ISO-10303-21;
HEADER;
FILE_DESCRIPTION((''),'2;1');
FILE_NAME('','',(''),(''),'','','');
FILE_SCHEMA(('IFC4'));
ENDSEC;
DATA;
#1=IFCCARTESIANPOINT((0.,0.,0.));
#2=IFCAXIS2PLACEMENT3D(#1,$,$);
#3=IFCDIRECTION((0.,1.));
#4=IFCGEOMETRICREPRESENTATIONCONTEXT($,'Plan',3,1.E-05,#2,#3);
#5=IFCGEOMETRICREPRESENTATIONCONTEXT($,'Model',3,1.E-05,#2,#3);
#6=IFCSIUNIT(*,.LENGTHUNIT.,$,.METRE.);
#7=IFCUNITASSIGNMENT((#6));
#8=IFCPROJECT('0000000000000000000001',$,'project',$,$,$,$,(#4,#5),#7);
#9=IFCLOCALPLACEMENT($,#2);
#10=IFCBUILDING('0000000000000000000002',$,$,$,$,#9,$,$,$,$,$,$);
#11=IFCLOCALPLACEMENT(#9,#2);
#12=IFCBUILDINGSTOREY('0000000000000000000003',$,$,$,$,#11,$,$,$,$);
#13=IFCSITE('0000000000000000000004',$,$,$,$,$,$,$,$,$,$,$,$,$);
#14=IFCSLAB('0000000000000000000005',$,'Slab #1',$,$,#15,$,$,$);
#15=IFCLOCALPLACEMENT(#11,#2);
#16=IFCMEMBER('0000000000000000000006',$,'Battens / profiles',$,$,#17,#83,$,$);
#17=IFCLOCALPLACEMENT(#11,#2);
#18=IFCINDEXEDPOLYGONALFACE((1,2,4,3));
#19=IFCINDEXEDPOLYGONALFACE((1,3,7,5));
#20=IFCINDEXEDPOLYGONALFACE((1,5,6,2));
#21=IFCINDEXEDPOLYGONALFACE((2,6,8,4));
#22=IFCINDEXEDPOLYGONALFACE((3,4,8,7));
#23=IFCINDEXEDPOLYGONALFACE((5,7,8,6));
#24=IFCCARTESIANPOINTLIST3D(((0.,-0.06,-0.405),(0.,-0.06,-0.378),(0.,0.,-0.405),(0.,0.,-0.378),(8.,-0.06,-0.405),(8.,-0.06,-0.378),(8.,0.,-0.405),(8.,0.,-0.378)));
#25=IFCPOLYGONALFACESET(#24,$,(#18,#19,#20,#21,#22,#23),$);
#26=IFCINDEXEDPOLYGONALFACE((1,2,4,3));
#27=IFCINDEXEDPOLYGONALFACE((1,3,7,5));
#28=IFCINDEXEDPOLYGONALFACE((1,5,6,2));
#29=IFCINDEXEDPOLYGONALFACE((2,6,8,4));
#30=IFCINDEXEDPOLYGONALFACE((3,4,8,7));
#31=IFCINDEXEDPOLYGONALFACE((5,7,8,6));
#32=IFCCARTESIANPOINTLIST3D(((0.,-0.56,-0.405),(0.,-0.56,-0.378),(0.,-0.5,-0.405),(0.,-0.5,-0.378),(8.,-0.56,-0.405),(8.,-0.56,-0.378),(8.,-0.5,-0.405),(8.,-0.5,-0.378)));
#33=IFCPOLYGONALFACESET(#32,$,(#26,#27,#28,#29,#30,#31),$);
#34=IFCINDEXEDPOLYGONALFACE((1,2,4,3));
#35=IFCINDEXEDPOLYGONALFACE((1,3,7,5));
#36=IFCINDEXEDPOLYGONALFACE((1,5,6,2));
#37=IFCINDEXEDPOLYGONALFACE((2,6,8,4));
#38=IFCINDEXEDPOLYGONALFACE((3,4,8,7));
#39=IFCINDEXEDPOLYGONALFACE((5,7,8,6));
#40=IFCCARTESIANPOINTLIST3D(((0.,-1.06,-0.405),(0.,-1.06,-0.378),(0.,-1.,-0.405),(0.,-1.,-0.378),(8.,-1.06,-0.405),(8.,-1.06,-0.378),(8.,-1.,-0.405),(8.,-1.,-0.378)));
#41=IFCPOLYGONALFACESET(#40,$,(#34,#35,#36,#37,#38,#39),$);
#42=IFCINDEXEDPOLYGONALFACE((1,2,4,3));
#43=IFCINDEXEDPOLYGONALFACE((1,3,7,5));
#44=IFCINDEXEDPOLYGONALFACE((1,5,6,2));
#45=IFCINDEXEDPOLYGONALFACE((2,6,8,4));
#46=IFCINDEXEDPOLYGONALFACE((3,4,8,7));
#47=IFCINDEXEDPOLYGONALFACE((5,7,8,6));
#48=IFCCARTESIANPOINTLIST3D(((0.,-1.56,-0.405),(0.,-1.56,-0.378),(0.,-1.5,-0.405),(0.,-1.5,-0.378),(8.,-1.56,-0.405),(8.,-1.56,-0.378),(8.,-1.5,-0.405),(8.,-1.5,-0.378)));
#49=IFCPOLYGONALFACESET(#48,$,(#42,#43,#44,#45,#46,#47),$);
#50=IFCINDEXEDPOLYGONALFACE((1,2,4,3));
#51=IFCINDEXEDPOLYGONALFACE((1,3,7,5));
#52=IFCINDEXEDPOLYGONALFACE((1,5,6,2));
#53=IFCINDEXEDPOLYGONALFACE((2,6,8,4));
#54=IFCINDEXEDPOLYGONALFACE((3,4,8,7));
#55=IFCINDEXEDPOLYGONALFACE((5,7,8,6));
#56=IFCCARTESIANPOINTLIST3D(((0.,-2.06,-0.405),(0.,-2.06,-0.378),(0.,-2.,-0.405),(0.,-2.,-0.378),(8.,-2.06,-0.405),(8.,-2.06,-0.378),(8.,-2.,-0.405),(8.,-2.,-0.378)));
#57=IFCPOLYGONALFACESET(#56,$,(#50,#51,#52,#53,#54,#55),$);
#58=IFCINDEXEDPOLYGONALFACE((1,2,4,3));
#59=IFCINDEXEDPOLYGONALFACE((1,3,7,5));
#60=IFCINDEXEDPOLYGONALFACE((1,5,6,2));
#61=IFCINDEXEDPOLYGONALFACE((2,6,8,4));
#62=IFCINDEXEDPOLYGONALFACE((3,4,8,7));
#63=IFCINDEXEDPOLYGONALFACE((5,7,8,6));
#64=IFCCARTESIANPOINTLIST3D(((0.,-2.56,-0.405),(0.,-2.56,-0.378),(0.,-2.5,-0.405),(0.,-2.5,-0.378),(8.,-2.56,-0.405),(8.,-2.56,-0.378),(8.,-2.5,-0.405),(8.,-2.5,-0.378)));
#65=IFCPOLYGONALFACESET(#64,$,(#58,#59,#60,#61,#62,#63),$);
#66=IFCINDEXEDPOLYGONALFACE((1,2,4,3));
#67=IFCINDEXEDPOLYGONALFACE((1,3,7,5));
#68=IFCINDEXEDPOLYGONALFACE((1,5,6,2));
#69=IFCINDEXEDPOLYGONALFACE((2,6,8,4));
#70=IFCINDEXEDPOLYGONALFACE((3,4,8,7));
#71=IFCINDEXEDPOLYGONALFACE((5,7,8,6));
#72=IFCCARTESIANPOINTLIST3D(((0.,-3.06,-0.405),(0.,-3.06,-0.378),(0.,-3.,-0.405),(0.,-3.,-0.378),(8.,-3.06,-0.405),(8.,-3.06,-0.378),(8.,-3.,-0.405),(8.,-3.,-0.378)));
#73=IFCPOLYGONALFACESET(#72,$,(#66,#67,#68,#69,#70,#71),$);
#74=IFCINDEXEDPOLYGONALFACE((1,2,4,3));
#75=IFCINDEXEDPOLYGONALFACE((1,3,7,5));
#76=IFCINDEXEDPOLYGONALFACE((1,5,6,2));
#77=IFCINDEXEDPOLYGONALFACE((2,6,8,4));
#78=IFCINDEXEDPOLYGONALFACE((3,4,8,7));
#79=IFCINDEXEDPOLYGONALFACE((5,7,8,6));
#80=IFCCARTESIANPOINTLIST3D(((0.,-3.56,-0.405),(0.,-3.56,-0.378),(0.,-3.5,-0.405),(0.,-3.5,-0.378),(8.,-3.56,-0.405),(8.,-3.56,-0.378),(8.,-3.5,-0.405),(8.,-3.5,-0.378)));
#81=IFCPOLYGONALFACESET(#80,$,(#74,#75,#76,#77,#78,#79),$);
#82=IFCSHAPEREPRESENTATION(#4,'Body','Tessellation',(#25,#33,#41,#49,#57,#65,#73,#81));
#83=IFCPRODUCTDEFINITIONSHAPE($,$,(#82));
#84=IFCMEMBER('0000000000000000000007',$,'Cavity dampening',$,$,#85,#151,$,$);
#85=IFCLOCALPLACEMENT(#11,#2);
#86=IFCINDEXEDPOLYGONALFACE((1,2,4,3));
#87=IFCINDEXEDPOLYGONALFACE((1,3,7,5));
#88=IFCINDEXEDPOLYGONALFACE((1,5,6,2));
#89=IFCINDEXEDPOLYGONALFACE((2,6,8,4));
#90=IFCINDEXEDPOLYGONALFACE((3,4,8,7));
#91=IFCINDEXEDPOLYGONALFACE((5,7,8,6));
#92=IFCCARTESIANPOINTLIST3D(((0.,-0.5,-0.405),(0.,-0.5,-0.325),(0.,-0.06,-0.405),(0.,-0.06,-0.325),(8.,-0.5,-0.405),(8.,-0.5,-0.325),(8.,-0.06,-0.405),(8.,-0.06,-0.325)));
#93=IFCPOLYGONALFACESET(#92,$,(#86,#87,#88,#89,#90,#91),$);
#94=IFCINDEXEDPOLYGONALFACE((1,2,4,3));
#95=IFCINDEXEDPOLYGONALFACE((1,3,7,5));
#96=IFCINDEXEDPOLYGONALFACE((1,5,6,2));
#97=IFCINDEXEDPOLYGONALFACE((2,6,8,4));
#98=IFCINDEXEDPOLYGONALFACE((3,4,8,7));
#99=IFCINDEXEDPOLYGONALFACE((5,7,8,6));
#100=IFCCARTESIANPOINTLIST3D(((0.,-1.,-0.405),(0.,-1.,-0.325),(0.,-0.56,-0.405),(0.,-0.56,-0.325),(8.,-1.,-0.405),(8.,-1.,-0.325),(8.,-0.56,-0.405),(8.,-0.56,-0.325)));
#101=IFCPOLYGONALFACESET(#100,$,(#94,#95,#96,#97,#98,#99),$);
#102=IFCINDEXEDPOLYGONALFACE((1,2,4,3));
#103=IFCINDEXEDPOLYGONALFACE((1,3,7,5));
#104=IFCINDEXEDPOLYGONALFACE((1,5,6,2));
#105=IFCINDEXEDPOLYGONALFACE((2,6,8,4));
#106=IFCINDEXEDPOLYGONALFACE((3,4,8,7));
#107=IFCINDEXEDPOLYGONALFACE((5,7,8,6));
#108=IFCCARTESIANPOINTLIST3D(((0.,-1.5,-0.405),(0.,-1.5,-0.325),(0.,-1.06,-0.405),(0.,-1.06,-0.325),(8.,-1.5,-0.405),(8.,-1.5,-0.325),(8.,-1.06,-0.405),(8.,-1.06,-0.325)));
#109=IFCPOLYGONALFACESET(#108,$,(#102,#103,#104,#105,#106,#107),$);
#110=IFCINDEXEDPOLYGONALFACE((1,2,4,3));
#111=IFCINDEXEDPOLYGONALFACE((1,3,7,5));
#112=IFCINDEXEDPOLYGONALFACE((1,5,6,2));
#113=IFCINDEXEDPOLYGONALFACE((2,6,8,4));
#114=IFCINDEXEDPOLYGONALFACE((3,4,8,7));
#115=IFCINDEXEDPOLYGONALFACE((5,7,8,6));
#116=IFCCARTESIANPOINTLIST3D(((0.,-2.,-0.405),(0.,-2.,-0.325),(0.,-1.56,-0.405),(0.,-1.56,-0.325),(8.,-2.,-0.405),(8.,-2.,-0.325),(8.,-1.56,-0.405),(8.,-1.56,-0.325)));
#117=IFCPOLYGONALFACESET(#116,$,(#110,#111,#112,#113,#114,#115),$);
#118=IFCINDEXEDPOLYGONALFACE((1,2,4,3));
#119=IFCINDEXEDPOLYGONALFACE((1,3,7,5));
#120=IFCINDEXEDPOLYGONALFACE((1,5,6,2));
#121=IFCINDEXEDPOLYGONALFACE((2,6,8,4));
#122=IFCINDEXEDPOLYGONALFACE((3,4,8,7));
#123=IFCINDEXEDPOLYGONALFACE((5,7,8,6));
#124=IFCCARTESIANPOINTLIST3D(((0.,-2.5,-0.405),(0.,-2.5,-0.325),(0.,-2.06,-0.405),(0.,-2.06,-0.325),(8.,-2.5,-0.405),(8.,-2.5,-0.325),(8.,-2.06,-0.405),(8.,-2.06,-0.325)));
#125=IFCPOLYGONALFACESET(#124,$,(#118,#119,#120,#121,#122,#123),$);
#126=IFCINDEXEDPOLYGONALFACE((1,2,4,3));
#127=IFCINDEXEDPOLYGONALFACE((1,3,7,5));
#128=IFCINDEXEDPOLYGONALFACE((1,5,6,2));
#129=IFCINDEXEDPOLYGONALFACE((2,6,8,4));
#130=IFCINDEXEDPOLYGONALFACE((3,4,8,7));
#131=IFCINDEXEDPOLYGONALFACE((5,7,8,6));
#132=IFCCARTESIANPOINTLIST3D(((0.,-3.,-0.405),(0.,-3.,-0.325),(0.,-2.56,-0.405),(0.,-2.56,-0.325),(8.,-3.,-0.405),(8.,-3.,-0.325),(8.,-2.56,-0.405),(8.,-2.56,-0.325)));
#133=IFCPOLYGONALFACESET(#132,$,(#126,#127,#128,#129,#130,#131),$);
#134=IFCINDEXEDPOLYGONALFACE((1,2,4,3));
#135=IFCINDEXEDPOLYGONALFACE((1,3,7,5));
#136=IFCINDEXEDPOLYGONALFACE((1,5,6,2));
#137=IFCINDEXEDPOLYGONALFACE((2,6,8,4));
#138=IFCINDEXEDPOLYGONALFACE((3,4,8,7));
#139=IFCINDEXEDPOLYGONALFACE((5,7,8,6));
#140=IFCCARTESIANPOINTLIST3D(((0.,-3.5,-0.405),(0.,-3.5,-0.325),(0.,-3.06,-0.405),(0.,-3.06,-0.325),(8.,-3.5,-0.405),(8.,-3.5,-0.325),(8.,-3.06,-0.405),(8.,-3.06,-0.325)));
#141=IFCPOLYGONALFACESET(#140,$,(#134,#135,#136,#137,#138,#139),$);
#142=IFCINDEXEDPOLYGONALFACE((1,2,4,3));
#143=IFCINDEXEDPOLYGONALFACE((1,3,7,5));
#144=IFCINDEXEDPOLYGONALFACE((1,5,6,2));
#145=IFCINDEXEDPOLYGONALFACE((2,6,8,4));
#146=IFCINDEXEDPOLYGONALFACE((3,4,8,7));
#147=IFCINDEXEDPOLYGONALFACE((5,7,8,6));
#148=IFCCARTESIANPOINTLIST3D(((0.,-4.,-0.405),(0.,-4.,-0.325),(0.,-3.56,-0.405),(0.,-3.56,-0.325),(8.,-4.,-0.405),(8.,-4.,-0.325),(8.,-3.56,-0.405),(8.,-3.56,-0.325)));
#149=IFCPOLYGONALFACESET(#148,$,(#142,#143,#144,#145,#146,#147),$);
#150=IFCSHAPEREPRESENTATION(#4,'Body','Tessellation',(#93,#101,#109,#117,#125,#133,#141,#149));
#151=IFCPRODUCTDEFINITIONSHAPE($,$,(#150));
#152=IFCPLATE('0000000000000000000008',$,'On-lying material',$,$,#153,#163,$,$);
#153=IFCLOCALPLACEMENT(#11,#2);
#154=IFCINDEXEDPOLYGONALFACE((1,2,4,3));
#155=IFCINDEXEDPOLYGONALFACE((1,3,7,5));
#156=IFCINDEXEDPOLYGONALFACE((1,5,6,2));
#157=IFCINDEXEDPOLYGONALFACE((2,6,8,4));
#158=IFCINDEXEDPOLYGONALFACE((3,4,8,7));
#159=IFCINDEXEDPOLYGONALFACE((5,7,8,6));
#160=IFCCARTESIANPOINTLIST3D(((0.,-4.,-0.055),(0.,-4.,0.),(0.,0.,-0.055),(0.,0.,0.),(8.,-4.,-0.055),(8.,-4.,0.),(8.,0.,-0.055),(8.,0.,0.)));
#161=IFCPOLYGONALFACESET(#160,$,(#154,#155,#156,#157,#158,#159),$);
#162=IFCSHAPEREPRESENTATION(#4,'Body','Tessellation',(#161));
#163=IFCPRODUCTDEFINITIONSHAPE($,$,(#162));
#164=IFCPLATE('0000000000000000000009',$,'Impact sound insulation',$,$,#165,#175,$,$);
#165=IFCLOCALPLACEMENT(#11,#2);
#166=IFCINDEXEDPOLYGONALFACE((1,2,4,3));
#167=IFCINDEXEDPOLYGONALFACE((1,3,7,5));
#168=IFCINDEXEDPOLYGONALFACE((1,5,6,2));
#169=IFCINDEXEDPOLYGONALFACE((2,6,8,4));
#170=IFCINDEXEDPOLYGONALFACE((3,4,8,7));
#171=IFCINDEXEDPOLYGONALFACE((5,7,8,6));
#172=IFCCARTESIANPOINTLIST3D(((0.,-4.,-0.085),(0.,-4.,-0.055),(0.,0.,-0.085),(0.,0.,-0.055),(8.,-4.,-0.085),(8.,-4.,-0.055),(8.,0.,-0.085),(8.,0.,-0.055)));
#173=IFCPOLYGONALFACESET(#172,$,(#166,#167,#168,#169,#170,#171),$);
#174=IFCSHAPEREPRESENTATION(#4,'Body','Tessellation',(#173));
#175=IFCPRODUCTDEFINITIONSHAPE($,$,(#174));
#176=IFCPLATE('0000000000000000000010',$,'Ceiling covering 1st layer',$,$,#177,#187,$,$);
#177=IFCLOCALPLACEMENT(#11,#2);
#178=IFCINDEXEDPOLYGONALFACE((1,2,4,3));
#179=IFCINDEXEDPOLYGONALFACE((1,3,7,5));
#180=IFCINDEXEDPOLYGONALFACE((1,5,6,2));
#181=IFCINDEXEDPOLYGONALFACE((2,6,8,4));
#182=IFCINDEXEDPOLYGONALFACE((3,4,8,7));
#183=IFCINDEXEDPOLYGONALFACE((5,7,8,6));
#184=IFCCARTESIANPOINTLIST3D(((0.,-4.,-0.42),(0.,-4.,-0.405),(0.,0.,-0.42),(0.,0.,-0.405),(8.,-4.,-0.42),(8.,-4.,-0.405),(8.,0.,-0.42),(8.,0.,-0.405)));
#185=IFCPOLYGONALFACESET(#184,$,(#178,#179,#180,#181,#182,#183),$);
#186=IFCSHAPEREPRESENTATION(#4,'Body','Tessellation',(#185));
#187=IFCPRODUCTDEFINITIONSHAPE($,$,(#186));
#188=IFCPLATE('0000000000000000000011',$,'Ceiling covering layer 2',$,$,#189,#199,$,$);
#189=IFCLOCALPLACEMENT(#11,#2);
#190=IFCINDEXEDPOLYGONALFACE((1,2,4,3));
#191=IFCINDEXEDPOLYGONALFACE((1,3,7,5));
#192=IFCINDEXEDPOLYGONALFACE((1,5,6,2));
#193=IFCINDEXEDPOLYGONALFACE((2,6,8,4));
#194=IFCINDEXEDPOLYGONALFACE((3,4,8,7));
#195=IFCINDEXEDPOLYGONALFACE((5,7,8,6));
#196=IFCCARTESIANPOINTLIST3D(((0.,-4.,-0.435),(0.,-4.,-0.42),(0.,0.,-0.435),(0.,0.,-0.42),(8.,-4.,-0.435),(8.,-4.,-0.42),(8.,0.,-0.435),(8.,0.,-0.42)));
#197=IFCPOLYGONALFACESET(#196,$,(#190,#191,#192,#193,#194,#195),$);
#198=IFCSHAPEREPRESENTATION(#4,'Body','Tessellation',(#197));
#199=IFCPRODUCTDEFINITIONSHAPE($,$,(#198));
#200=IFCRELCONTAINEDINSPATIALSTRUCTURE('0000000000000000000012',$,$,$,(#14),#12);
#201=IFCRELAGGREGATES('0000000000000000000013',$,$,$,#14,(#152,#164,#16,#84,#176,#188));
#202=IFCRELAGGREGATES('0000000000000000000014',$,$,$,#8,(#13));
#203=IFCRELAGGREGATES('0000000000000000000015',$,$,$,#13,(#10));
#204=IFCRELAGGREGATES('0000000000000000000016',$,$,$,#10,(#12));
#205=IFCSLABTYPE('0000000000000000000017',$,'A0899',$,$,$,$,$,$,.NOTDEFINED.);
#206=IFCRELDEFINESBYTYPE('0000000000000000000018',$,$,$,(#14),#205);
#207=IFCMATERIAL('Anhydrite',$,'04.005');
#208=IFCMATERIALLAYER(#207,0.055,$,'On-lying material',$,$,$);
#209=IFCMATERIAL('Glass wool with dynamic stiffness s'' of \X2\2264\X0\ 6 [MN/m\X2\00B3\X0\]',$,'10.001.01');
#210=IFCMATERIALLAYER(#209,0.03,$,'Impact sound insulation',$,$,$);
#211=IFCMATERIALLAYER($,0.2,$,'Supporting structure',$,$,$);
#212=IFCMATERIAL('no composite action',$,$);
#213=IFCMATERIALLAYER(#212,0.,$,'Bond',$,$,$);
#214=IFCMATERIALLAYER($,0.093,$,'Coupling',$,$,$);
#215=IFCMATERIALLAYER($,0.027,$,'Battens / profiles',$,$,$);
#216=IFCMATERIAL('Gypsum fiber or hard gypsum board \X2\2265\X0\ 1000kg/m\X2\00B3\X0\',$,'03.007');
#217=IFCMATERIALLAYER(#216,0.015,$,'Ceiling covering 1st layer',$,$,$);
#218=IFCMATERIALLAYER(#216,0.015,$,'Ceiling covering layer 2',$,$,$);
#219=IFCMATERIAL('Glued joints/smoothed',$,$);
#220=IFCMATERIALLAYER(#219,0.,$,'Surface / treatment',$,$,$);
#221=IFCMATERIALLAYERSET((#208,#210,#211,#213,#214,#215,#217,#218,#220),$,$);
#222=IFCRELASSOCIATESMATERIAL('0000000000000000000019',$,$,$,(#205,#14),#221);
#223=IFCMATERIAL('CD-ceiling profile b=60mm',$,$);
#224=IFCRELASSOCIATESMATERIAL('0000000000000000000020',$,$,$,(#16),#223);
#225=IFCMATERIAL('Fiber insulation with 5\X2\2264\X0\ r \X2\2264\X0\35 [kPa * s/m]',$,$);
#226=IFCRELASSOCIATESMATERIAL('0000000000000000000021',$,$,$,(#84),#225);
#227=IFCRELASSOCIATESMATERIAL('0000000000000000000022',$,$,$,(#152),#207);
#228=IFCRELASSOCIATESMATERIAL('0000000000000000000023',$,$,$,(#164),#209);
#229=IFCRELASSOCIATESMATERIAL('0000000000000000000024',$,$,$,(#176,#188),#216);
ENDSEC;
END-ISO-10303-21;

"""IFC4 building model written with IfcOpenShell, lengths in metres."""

from ifc_helpers import new_model, si_unit, direction, frame, frame_2d, origin, origin_with_axes, place, context, project, spatial, rectangle, extrude, material, layer, layer_set, type_object, element, aggregate, save


model = new_model("IFC4")

# Units and contexts
plan_context = context("Plan", 3, precision=1e-05, world=origin(), true_north=direction((0.0, 1.0)))
model_context = context("Model", 3, precision=1e-05, world=origin(), true_north=direction((0.0, 1.0)))
ifc_project = project(units=[si_unit("LENGTHUNIT", "METRE")], contexts=[plan_context, model_context])

# Site, building, storey
site = spatial("IfcSite", under=ifc_project)
building_placement = place(None, origin())
building = spatial("IfcBuilding", under=site, at=building_placement)
storey_placement = place(building_placement, origin())
storey = spatial("IfcBuildingStorey", under=building, at=storey_placement)

# Slab, members, plates
ifc_material_1 = material(Name="Anhydrite", Category="04.005")
ifc_layer_1 = layer(ifc_material_1, 0.055, Name="On-lying material")
ifc_material_2 = material(Name="Glass wool with dynamic stiffness s' of ≤ 6 [MN/m³]", Category="10.001.01")
ifc_layer_2 = layer(ifc_material_2, 0.03, Name="Impact sound insulation")
ifc_layer_3 = layer(None, 0.2, Name="Supporting structure")
ifc_material_3 = material(Name="no composite action")
ifc_layer_4 = layer(ifc_material_3, 0.0, Name="Bond")
ifc_layer_5 = layer(None, 0.093, Name="Coupling")
ifc_layer_6 = layer(None, 0.027, Name="Battens / profiles")
ifc_material_4 = material(Name="Gypsum fiber or hard gypsum board ≥ 1000kg/m³", Category="03.007")
ifc_layer_7 = layer(ifc_material_4, 0.015, Name="Ceiling covering 1st layer")
ifc_layer_8 = layer(ifc_material_4, 0.015, Name="Ceiling covering layer 2")
ifc_material_5 = material(Name="Glued joints/smoothed")
ifc_layer_9 = layer(ifc_material_5, 0.0, Name="Surface / treatment")
ifc_layer_set = layer_set([ifc_layer_1, ifc_layer_2, ifc_layer_3, ifc_layer_4, ifc_layer_5, ifc_layer_6, ifc_layer_7, ifc_layer_8, ifc_layer_9])
slab_type = type_object("IfcSlabType", Name="A0899", PredefinedType="NOTDEFINED", material=ifc_layer_set)
slab_placement = place(None, frame((0.0, 0.0, 0.0), z_axis=(0.0, 0.0, -1.0), x_axis=(1.0, 0.0, 0.0)))
slab = element("IfcSlab", 1, at=slab_placement, inside=storey, type_object=slab_type, material=ifc_layer_set, Name="Slab #1")
ifc_material_6 = material(Name="CD-ceiling profile b=60mm")
member_1_placement = place(slab_placement, origin())
member_1 = element("IfcMember", 2, at=member_1_placement, material=ifc_material_6, Name="Battens / profiles", context=plan_context, shape_type="SweptSolid", body=[
    extrude(rectangle(XDim=0.06, YDim=0.027, at=frame_2d((0.03, 0.0135), x_axis=(1.0, 0.0))), frame((0.0, 0.0, 0.378), z_axis=(1.0, 0.0, 0.0), x_axis=(0.0, 1.0, 0.0)), (0.0, 0.0, 1.0), 8.0),
    extrude(rectangle(XDim=0.06, YDim=0.027, at=frame_2d((0.03, 0.0135), x_axis=(1.0, 0.0))), frame((0.0, 0.5, 0.378), z_axis=(1.0, 0.0, 0.0), x_axis=(0.0, 1.0, 0.0)), (0.0, 0.0, 1.0), 8.0),
    extrude(rectangle(XDim=0.06, YDim=0.027, at=frame_2d((0.03, 0.0135), x_axis=(1.0, 0.0))), frame((0.0, 1.0, 0.378), z_axis=(1.0, 0.0, 0.0), x_axis=(0.0, 1.0, 0.0)), (0.0, 0.0, 1.0), 8.0),
    extrude(rectangle(XDim=0.06, YDim=0.027, at=frame_2d((0.03, 0.0135), x_axis=(1.0, 0.0))), frame((0.0, 1.5, 0.378), z_axis=(1.0, 0.0, 0.0), x_axis=(0.0, 1.0, 0.0)), (0.0, 0.0, 1.0), 8.0),
    extrude(rectangle(XDim=0.06, YDim=0.027, at=frame_2d((0.03, 0.0135), x_axis=(1.0, 0.0))), frame((0.0, 2.0, 0.378), z_axis=(1.0, 0.0, 0.0), x_axis=(0.0, 1.0, 0.0)), (0.0, 0.0, 1.0), 8.0),
    extrude(rectangle(XDim=0.06, YDim=0.027, at=frame_2d((0.03, 0.0135), x_axis=(1.0, 0.0))), frame((0.0, 2.5, 0.378), z_axis=(1.0, 0.0, 0.0), x_axis=(0.0, 1.0, 0.0)), (0.0, 0.0, 1.0), 8.0),
    extrude(rectangle(XDim=0.06, YDim=0.027, at=frame_2d((0.03, 0.0135), x_axis=(1.0, 0.0))), frame((0.0, 3.0, 0.378), z_axis=(1.0, 0.0, 0.0), x_axis=(0.0, 1.0, 0.0)), (0.0, 0.0, 1.0), 8.0),
    extrude(rectangle(XDim=0.06, YDim=0.027, at=frame_2d((0.03, 0.0135), x_axis=(1.0, 0.0))), frame((0.0, 3.5, 0.378), z_axis=(1.0, 0.0, 0.0), x_axis=(0.0, 1.0, 0.0)), (0.0, 0.0, 1.0), 8.0),
])
ifc_material_7 = material(Name="Fiber insulation with 5≤ r ≤35 [kPa * s/m]")
member_2_placement = place(slab_placement, origin())
member_2 = element("IfcMember", 3, at=member_2_placement, material=ifc_material_7, Name="Cavity dampening", context=plan_context, shape_type="SweptSolid", body=[
    extrude(rectangle(XDim=0.44, YDim=0.08, at=frame_2d((0.22, 0.04), x_axis=(1.0, 0.0))), frame((0.0, 0.06, 0.325), z_axis=(1.0, 0.0, 0.0), x_axis=(0.0, 1.0, 0.0)), (0.0, 0.0, 1.0), 8.0),
    extrude(rectangle(XDim=0.44, YDim=0.08, at=frame_2d((0.22, 0.04), x_axis=(1.0, 0.0))), frame((0.0, 0.56, 0.325), z_axis=(1.0, 0.0, 0.0), x_axis=(0.0, 1.0, 0.0)), (0.0, 0.0, 1.0), 8.0),
    extrude(rectangle(XDim=0.44, YDim=0.08, at=frame_2d((0.22, 0.04), x_axis=(1.0, 0.0))), frame((0.0, 1.06, 0.325), z_axis=(1.0, 0.0, 0.0), x_axis=(0.0, 1.0, 0.0)), (0.0, 0.0, 1.0), 8.0),
    extrude(rectangle(XDim=0.44, YDim=0.08, at=frame_2d((0.22, 0.04), x_axis=(1.0, 0.0))), frame((0.0, 1.56, 0.325), z_axis=(1.0, 0.0, 0.0), x_axis=(0.0, 1.0, 0.0)), (0.0, 0.0, 1.0), 8.0),
    extrude(rectangle(XDim=0.44, YDim=0.08, at=frame_2d((0.22, 0.04), x_axis=(1.0, 0.0))), frame((0.0, 2.06, 0.325), z_axis=(1.0, 0.0, 0.0), x_axis=(0.0, 1.0, 0.0)), (0.0, 0.0, 1.0), 8.0),
    extrude(rectangle(XDim=0.44, YDim=0.08, at=frame_2d((0.22, 0.04), x_axis=(1.0, 0.0))), frame((0.0, 2.56, 0.325), z_axis=(1.0, 0.0, 0.0), x_axis=(0.0, 1.0, 0.0)), (0.0, 0.0, 1.0), 8.0),
    extrude(rectangle(XDim=0.44, YDim=0.08, at=frame_2d((0.22, 0.04), x_axis=(1.0, 0.0))), frame((0.0, 3.06, 0.325), z_axis=(1.0, 0.0, 0.0), x_axis=(0.0, 1.0, 0.0)), (0.0, 0.0, 1.0), 8.0),
    extrude(rectangle(XDim=0.44, YDim=0.08, at=frame_2d((0.22, 0.04), x_axis=(1.0, 0.0))), frame((0.0, 3.56, 0.325), z_axis=(1.0, 0.0, 0.0), x_axis=(0.0, 1.0, 0.0)), (0.0, 0.0, 1.0), 8.0),
])
plate_1_placement = place(slab_placement, origin())
plate_1 = element("IfcPlate", 4, at=plate_1_placement, material=ifc_material_1, Name="On-lying material", context=plan_context, shape_type="SweptSolid", body=[
    extrude(rectangle(XDim=8.0, YDim=4.0, at=frame_2d((4.0, 2.0), x_axis=(1.0, 0.0))), origin_with_axes(), (0.0, 0.0, 1.0), 0.055),
])
plate_2_placement = place(slab_placement, origin())
plate_2 = element("IfcPlate", 5, at=plate_2_placement, material=ifc_material_2, Name="Impact sound insulation", context=plan_context, shape_type="SweptSolid", body=[
    extrude(rectangle(XDim=8.0, YDim=4.0, at=frame_2d((4.0, 2.0), x_axis=(1.0, 0.0))), frame((0.0, 0.0, 0.055), z_axis=(0.0, 0.0, 1.0), x_axis=(1.0, 0.0, 0.0)), (0.0, 0.0, 1.0), 0.03),
])
plate_3_placement = place(slab_placement, origin())
plate_3 = element("IfcPlate", 6, at=plate_3_placement, material=ifc_material_4, Name="Ceiling covering 1st layer", context=plan_context, shape_type="SweptSolid", body=[
    extrude(rectangle(XDim=8.0, YDim=4.0, at=frame_2d((4.0, 2.0), x_axis=(1.0, 0.0))), frame((0.0, 0.0, 0.405), z_axis=(0.0, 0.0, 1.0), x_axis=(1.0, 0.0, 0.0)), (0.0, 0.0, 1.0), 0.015),
])
plate_4_placement = place(slab_placement, origin())
plate_4 = element("IfcPlate", 7, at=plate_4_placement, material=ifc_material_4, Name="Ceiling covering layer 2", context=plan_context, shape_type="SweptSolid", body=[
    extrude(rectangle(XDim=8.0, YDim=4.0, at=frame_2d((4.0, 2.0), x_axis=(1.0, 0.0))), frame((0.0, 0.0, 0.42), z_axis=(0.0, 0.0, 1.0), x_axis=(1.0, 0.0, 0.0)), (0.0, 0.0, 1.0), 0.015),
])
aggregate(slab, [plate_1, plate_2, member_1, member_2, plate_3, plate_4])

save(model, "model.ifc")
